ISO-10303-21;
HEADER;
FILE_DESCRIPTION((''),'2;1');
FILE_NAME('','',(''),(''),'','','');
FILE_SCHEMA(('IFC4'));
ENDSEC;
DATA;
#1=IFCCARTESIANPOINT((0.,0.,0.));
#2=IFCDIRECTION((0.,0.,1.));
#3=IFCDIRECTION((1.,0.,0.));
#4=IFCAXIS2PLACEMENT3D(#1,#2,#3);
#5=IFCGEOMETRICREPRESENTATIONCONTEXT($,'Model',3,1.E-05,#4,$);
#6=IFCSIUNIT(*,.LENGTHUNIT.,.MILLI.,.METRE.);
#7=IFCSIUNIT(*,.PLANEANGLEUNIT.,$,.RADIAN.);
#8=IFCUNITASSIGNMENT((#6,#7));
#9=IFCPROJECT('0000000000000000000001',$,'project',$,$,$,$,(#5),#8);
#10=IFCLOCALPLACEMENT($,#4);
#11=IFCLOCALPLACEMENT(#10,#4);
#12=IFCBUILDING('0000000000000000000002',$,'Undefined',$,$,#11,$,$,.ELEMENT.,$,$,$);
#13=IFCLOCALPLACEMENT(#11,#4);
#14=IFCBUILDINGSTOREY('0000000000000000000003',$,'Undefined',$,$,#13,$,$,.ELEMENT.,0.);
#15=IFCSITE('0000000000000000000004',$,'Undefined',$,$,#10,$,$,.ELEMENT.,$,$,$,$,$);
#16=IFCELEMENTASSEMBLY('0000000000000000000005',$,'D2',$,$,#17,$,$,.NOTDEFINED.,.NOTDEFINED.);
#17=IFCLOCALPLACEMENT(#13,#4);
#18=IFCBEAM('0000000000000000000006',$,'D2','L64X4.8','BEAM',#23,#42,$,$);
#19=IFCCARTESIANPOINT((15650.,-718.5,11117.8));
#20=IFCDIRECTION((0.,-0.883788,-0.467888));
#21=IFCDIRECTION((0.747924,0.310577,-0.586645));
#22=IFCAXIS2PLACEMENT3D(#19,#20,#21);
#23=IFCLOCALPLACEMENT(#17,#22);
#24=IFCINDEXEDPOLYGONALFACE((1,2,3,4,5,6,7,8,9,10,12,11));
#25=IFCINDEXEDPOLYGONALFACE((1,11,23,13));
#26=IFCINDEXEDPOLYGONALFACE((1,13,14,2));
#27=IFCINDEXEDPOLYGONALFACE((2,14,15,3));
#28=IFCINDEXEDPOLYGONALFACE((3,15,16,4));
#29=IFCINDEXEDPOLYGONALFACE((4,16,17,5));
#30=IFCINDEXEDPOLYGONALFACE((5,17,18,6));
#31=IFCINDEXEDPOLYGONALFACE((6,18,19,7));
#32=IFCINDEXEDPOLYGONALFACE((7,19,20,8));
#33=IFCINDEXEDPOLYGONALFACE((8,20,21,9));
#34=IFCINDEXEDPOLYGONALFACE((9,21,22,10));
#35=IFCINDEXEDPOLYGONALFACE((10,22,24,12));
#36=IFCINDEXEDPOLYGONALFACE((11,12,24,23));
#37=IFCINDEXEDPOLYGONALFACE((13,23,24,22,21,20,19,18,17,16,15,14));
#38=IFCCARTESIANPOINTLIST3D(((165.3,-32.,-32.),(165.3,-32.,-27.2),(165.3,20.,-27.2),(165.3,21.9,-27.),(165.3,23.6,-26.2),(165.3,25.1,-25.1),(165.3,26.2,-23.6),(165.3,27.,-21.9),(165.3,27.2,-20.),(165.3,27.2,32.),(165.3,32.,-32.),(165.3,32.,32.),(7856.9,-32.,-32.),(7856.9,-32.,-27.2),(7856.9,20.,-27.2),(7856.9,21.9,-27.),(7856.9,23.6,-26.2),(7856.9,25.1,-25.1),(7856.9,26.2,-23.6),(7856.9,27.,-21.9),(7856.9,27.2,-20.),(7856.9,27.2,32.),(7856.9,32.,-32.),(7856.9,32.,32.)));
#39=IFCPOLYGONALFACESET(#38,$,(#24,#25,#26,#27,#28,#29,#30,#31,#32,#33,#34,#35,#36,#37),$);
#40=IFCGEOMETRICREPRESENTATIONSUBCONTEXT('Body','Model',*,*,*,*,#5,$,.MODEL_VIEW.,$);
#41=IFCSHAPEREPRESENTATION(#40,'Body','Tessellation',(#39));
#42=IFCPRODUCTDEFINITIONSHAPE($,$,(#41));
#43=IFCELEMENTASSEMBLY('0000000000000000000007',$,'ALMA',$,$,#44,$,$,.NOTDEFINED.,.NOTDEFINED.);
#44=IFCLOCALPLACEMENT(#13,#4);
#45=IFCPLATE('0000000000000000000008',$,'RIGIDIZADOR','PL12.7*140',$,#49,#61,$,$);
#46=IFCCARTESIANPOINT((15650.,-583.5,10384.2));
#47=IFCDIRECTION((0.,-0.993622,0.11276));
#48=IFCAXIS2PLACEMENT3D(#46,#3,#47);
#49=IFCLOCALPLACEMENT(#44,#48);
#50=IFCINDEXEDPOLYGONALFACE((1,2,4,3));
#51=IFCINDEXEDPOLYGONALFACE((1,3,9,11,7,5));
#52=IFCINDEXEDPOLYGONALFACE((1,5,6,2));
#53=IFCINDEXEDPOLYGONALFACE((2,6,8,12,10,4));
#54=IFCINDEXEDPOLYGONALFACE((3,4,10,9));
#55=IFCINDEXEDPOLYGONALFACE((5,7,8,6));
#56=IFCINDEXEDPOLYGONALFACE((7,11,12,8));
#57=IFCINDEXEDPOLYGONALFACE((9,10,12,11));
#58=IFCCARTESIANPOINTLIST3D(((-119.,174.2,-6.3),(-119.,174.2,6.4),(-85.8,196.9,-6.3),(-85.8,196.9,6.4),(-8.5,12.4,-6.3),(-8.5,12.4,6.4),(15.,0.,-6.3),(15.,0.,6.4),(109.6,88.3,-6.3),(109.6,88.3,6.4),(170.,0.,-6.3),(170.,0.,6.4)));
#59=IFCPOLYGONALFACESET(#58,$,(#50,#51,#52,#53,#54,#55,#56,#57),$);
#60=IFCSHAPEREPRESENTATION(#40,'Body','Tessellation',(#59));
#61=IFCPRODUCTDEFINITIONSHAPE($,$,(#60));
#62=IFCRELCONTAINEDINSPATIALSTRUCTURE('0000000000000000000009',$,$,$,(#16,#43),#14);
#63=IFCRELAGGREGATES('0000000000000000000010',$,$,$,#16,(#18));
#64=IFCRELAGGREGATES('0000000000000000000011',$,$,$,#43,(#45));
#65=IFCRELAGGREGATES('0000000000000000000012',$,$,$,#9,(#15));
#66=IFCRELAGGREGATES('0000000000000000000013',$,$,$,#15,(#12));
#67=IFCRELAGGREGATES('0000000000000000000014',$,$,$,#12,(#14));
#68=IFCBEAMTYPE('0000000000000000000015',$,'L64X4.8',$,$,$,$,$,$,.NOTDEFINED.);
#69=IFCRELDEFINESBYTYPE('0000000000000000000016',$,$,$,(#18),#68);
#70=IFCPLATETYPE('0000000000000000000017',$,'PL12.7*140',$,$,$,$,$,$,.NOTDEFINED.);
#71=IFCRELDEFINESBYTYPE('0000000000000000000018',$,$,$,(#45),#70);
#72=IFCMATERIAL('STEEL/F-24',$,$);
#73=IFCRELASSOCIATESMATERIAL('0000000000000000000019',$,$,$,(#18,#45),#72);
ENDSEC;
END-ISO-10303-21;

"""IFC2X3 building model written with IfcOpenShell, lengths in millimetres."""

from ifc_helpers import new_model, si_unit, frame, origin_with_axes, origin_2d_with_axis, place, context, subcontext, project, spatial, polyline, l_section, outline, extrude, clip, halfspace, material, type_object, element, aggregate, save


model = new_model("IFC2X3")

# Units and contexts
model_context = context("Model", 3, precision=1e-05, world=origin_with_axes())
body_context = subcontext(model_context, "Body", "Model", "MODEL_VIEW")
ifc_project = project(units=[si_unit("LENGTHUNIT", "METRE", prefix="MILLI"), si_unit("PLANEANGLEUNIT", "RADIAN")], contexts=[model_context])

# Site, building, storey
site_placement = place(None, origin_with_axes())
site = spatial("IfcSite", under=ifc_project, at=site_placement, Name="Undefined", CompositionType="ELEMENT")
building_placement = place(site_placement, origin_with_axes())
building = spatial("IfcBuilding", under=site, at=building_placement, Name="Undefined", CompositionType="ELEMENT")
storey_placement = place(building_placement, origin_with_axes())
storey = spatial("IfcBuildingStorey", under=building, at=storey_placement, Name="Undefined", CompositionType="ELEMENT", Elevation=0.0)

# Element assembly, beam
assembly_1_placement = place(storey_placement, origin_with_axes())
assembly_1 = element("IfcElementAssembly", 1, at=assembly_1_placement, inside=storey, Name="D2", AssemblyPlace="NOTDEFINED", PredefinedType="NOTDEFINED")
ifc_material_1 = material(Name="STEEL/F-24")
beam_type = type_object("IfcBeamType", Name="L64X4.8", PredefinedType="NOTDEFINED")
beam_placement = place(assembly_1_placement, frame((15650.0, -718.5, 11117.8), z_axis=(0.0, -0.883788, -0.467888), x_axis=(0.747924, 0.310577, -0.586645)))
beam = element("IfcBeam", 2, at=beam_placement, type_object=beam_type, material=ifc_material_1, Name="D2", Description="L64X4.8", ObjectType="BEAM", context=body_context, shape_type="Clipping", body=[
    clip(clip(extrude(l_section(Depth=64.0, Width=64.0, Thickness=4.8, FilletRadius=7.2, at=origin_2d_with_axis()), frame((7940.2, 0.0, 0.0), z_axis=(-1.0, 0.0, 0.0), x_axis=(0.0, -1.0, 0.0)), (0.0, 0.0, 1.0), 7940.1), halfspace(frame((7856.9, 0.0, -32.0), z_axis=(-1.0, 0.0, 0.0), x_axis=(0.0, -0.000002, -1.0)), True)), halfspace(frame((165.3, 0.0, -25.6), z_axis=(1.0, 0.0, 0.0), x_axis=(0.0, 0.0, -1.0)), True)),
])
aggregate(assembly_1, [beam])

# Element assembly, plate
assembly_2_placement = place(storey_placement, origin_with_axes())
assembly_2 = element("IfcElementAssembly", 3, at=assembly_2_placement, inside=storey, Name="ALMA", AssemblyPlace="NOTDEFINED", PredefinedType="NOTDEFINED")
plate_type_1 = type_object("IfcPlateType", Name="PL12.7*140", PredefinedType="NOTDEFINED")
plate_1_placement = place(assembly_2_placement, frame((15650.0, -583.5, 10384.2), z_axis=(1.0, 0.0, 0.0), x_axis=(0.0, -0.993622, 0.11276)))
plate_1 = element("IfcPlate", 4, at=plate_1_placement, type_object=plate_type_1, material=ifc_material_1, Name="RIGIDIZADOR", Description="PL12.7*140", context=body_context, shape_type="SweptSolid", body=[
    extrude(outline(polyline([(-8.5, 12.4), (15.0, 0.0), (170.0, 0.0), (109.6, 88.3), (-85.8, 196.9), (-119.0, 174.2), (-8.5, 12.4)])), frame((0.0, 0.0, -6.3), z_axis=(0.0, 0.0, 1.0), x_axis=(1.0, 0.0, 0.0)), (0.0, 0.0, 1.0), 12.7),
])
aggregate(assembly_2, [plate_1])

save(model, "model.ifc")
